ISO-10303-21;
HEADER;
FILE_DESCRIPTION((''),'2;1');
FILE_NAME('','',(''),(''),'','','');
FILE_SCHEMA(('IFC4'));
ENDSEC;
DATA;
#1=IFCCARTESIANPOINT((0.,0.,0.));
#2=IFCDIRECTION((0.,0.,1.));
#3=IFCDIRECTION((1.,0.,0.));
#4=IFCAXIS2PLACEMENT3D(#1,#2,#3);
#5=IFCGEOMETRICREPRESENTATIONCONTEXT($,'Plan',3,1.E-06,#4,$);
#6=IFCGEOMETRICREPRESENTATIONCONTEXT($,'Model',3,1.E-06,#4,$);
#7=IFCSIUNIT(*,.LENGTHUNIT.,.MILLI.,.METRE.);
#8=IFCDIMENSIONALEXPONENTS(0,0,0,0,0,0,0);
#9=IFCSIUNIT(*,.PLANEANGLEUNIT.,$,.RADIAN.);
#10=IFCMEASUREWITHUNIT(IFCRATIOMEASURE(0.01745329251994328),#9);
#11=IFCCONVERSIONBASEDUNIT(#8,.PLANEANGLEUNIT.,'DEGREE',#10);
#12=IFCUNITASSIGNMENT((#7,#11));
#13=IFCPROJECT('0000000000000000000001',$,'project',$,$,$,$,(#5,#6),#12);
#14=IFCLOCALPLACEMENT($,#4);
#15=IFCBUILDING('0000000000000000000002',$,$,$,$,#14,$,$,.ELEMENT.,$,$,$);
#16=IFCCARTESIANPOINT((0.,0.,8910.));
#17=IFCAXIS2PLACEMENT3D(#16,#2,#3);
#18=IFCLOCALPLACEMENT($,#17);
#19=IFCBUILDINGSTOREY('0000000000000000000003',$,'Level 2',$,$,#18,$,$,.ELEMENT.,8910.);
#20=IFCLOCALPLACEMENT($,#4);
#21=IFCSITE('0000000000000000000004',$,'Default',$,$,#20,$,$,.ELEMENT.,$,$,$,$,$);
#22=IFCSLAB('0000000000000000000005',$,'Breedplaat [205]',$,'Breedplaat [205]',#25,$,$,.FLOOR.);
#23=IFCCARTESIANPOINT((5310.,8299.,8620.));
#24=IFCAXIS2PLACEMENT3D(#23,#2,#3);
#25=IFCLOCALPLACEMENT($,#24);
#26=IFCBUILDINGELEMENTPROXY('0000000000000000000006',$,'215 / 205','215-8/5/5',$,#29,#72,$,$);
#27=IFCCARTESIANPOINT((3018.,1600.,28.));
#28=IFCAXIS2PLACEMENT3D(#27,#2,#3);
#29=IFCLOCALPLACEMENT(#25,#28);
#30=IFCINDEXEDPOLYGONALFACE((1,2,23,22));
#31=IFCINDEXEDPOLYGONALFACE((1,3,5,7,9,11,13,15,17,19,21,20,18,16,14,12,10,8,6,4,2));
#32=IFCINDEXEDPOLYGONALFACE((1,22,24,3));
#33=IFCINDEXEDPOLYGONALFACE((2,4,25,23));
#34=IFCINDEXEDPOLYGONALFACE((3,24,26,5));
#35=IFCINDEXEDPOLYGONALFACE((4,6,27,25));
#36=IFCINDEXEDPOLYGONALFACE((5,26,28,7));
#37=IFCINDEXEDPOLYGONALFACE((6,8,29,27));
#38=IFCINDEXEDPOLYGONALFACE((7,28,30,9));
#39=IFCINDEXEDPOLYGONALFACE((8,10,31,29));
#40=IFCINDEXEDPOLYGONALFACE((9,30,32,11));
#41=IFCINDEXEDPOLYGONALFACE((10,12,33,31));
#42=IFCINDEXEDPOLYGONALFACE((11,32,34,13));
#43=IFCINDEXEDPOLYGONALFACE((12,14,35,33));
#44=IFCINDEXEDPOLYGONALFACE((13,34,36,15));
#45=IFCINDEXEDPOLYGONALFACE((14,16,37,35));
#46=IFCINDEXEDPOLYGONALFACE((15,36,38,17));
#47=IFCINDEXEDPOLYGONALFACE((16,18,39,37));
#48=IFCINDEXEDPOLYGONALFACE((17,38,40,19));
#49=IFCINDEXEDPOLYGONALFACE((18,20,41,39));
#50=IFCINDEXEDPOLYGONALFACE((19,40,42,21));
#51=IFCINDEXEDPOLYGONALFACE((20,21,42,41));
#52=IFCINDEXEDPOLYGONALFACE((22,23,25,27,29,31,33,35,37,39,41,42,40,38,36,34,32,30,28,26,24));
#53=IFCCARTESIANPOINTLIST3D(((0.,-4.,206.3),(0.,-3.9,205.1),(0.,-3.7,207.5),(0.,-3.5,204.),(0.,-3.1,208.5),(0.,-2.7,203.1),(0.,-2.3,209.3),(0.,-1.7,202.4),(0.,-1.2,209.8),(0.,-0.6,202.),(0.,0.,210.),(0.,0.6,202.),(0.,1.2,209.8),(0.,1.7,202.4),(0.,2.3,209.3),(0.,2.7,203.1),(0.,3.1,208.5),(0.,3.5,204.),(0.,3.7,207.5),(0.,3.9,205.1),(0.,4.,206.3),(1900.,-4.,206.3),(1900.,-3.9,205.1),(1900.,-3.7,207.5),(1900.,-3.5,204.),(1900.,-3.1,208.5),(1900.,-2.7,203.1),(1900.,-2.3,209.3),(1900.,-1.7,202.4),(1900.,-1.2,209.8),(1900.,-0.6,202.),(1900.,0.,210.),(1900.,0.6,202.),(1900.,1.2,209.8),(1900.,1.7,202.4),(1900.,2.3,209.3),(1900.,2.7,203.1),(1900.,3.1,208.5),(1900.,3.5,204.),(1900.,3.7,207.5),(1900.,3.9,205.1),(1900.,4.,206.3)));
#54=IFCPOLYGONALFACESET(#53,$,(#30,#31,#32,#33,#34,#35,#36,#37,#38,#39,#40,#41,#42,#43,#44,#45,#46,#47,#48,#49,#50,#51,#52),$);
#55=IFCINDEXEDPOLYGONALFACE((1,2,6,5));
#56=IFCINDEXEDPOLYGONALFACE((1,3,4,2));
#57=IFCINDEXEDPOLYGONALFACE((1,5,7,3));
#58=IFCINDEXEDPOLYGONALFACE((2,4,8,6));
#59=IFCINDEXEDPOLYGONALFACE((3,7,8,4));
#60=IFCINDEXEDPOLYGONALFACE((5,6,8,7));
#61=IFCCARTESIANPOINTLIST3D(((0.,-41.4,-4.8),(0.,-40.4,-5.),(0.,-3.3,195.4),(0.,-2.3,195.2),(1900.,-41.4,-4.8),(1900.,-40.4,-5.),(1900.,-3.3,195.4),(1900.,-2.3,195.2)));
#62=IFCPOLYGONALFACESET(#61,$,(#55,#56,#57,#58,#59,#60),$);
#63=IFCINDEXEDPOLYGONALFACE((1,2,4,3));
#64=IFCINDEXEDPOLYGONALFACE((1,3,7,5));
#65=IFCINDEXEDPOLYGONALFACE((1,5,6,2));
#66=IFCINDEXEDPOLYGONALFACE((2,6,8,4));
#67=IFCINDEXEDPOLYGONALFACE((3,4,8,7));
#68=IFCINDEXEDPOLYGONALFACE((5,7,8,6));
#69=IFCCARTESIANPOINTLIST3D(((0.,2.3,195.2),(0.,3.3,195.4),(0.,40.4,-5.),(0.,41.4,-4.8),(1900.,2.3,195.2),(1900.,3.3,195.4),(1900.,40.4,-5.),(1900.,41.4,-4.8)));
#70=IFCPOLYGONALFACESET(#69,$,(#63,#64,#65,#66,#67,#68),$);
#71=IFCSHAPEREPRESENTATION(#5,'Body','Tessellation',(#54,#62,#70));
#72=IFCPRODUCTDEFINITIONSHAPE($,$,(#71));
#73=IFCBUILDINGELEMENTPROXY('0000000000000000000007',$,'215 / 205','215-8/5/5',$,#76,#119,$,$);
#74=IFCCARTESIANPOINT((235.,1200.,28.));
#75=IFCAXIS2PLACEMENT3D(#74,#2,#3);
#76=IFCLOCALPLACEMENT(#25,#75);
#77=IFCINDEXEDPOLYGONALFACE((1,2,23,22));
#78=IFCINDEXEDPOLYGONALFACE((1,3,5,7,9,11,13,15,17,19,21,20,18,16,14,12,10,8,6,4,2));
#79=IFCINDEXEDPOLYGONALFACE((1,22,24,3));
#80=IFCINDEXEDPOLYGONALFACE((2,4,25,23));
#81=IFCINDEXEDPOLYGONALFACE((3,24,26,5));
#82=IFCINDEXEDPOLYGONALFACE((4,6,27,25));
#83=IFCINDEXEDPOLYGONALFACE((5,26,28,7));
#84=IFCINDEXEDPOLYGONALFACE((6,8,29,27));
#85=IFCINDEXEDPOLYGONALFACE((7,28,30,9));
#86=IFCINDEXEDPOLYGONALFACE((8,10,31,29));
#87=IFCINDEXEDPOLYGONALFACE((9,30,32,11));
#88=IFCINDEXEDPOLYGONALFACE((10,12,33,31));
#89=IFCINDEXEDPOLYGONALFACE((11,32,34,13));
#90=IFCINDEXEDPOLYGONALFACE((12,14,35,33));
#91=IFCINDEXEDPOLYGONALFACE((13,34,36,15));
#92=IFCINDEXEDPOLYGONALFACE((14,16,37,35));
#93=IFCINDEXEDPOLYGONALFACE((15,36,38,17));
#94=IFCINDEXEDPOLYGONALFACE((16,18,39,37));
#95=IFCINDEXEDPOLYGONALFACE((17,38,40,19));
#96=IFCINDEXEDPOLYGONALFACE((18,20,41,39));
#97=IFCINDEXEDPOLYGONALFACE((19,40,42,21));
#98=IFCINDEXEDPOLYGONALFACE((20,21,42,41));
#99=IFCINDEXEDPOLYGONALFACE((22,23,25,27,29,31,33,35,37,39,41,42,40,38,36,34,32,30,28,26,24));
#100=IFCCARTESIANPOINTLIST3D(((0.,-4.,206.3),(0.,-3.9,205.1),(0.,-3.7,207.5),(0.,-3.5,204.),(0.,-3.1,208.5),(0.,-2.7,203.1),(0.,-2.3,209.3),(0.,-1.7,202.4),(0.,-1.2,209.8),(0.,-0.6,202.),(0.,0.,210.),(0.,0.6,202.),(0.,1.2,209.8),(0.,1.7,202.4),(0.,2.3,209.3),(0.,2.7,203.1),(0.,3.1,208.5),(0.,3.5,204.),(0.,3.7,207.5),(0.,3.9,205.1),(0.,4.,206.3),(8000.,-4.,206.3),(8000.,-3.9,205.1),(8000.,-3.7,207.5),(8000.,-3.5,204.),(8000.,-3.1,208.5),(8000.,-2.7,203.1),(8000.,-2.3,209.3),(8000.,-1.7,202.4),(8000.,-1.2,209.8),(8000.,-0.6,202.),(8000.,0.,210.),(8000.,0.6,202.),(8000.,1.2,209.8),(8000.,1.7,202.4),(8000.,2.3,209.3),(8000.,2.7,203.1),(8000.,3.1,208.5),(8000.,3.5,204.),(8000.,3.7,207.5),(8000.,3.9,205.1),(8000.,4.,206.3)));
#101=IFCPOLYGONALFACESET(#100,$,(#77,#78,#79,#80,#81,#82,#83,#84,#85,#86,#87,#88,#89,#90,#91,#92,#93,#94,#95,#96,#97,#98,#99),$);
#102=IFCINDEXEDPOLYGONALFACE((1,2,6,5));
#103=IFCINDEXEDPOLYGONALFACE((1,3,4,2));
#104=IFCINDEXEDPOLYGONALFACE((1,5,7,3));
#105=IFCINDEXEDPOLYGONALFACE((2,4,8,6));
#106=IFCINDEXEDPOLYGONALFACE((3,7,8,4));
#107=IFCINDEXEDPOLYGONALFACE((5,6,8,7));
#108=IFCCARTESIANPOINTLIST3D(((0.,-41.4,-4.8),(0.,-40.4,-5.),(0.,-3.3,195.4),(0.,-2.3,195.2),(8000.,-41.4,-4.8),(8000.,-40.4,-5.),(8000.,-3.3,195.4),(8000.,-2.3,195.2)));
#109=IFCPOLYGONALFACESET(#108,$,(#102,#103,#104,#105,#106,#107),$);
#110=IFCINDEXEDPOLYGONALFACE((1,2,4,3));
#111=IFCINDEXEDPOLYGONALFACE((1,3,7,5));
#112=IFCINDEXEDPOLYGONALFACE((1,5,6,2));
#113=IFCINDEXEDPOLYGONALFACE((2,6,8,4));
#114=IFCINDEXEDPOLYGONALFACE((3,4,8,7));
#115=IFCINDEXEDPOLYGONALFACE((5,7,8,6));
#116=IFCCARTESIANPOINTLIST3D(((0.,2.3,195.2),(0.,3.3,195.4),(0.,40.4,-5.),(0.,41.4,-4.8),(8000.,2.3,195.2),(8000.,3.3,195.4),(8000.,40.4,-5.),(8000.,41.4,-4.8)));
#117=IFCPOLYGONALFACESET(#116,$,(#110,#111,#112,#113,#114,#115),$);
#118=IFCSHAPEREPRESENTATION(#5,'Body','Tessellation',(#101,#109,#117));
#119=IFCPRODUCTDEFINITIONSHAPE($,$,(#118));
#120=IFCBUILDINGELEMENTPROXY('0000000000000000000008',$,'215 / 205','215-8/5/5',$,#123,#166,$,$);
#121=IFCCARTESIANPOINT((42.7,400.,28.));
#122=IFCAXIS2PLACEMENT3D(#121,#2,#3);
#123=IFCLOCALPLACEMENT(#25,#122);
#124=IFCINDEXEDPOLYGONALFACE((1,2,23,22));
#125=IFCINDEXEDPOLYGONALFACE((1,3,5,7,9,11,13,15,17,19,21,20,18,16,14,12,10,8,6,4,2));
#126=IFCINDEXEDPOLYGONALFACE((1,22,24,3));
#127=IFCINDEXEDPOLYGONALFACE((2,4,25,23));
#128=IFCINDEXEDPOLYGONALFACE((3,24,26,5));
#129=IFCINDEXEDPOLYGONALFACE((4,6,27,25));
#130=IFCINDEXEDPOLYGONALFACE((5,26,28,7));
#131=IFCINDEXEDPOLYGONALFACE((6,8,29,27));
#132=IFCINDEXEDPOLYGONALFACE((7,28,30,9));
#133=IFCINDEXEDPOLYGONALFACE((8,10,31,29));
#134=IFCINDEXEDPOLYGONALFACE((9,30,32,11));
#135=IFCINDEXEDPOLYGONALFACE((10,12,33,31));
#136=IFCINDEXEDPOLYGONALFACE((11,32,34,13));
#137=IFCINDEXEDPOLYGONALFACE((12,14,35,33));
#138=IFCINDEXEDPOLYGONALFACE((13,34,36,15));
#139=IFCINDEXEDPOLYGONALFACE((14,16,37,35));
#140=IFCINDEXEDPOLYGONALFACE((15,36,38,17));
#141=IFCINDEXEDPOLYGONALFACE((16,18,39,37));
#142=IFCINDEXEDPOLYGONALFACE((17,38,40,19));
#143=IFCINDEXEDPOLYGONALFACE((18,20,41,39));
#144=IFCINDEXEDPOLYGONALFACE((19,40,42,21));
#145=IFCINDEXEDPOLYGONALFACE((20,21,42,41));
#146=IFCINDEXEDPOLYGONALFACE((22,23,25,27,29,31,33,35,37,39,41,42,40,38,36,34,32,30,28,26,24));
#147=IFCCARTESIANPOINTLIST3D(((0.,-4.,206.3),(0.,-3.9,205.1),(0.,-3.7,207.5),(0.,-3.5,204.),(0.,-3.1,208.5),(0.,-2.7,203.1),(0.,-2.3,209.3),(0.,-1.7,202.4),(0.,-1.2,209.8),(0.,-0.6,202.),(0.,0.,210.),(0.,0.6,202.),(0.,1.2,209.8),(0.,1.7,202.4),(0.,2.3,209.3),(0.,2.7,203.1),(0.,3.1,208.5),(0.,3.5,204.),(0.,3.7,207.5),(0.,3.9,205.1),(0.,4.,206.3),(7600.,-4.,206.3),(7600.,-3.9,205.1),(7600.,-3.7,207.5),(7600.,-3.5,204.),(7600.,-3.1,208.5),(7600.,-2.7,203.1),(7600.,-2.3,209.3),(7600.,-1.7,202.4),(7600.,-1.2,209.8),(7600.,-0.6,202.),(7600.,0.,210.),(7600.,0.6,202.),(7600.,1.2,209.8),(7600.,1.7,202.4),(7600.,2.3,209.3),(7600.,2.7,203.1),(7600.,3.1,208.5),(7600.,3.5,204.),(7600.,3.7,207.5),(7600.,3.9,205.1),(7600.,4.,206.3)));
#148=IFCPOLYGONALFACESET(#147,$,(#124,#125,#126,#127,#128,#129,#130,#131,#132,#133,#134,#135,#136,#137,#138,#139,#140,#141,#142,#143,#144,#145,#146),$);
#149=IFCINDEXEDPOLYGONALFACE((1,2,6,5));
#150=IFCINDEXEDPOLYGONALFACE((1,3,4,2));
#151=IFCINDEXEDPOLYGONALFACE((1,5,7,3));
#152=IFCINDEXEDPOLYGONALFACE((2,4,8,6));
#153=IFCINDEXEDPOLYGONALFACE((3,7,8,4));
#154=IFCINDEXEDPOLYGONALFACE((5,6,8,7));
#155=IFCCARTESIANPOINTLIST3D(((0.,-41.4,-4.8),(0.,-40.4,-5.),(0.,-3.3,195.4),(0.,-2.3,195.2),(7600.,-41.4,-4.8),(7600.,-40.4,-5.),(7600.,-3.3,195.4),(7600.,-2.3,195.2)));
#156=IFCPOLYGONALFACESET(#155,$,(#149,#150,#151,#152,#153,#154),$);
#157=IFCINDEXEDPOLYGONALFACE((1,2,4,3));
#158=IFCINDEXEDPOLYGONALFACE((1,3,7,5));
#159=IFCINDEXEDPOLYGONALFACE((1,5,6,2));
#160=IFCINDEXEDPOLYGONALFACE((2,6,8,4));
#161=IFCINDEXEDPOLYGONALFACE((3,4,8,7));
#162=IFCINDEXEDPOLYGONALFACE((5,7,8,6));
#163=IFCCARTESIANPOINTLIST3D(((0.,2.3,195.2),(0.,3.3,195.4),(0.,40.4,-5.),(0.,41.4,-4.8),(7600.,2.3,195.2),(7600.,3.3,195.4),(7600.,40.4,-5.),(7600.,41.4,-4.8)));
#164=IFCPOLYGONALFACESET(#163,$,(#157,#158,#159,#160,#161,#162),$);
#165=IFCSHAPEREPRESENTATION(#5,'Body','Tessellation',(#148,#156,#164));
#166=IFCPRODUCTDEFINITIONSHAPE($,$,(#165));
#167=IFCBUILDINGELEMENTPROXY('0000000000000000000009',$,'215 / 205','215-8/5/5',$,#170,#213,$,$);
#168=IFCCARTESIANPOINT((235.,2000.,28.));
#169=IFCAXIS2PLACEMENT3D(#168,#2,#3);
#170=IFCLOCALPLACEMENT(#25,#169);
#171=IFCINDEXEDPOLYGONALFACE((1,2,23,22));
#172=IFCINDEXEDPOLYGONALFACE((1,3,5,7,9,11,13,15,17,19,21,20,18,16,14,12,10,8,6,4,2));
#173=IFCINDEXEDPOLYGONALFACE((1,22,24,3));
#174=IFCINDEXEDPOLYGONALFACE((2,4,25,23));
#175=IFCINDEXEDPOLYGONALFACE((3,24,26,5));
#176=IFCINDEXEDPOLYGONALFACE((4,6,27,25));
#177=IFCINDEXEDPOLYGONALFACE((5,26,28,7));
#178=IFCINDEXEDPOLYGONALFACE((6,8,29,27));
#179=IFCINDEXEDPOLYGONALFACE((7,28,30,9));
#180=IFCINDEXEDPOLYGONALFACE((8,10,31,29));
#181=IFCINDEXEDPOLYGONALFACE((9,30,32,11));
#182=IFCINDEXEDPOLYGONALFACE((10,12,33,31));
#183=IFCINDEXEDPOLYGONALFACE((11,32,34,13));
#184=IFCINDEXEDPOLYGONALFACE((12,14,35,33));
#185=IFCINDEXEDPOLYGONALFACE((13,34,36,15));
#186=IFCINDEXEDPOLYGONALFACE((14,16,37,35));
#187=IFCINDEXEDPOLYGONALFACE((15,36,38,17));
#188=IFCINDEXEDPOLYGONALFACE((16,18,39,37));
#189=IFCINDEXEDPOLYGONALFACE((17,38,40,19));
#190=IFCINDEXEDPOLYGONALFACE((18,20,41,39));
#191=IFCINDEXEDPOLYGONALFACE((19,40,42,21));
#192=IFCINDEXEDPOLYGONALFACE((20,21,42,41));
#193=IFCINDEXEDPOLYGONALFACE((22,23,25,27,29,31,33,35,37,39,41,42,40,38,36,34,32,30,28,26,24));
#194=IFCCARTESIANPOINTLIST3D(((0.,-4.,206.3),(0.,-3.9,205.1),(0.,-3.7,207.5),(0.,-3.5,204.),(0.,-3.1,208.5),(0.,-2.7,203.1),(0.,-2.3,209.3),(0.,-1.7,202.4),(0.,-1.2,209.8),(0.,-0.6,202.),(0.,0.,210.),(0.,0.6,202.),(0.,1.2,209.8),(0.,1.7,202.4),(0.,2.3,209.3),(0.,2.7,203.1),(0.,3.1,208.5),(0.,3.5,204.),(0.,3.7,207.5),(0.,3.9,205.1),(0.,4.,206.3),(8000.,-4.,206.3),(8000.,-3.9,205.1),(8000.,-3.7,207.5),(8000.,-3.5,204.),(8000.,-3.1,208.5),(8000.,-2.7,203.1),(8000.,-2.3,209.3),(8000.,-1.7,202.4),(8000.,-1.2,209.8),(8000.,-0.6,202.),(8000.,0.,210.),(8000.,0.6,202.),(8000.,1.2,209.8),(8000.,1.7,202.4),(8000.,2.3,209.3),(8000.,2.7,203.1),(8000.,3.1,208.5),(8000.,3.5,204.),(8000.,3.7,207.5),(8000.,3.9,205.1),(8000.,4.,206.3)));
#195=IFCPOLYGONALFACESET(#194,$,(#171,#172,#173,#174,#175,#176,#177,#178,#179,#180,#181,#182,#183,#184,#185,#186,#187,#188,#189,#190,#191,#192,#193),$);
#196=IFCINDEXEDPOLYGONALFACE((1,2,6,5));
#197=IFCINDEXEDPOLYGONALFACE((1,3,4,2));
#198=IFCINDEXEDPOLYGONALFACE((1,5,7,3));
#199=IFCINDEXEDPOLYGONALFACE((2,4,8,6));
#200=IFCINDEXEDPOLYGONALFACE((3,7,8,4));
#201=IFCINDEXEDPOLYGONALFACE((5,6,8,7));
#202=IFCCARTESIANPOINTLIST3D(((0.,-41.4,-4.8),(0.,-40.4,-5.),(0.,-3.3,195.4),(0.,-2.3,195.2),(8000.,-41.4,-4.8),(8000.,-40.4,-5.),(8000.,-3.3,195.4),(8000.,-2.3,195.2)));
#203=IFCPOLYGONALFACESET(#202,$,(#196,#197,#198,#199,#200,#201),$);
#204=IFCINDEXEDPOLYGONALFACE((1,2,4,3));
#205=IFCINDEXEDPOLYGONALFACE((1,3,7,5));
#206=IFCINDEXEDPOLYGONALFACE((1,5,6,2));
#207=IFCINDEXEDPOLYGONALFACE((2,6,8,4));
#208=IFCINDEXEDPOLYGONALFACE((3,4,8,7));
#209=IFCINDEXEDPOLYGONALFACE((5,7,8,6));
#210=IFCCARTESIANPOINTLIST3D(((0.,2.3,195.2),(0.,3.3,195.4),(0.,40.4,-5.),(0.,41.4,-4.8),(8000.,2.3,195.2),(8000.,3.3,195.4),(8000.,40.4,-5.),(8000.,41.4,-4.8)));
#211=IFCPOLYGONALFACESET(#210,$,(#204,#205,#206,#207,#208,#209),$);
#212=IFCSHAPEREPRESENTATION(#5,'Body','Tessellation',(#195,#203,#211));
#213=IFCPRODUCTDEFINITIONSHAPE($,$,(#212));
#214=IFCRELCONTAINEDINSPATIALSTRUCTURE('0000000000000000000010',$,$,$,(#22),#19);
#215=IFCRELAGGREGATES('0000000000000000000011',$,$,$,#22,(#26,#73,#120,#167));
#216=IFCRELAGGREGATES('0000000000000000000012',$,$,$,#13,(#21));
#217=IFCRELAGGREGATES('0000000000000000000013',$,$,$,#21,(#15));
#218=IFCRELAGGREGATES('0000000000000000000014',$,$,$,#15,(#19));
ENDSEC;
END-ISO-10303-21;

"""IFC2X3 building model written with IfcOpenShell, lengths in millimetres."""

from ifc_helpers import new_model, entity, si_unit, converted_unit, frame, origin_with_axes, origin_2d_with_axis, place, context, project, spatial, rectangle, circle, extrude, element, aggregate, save


model = new_model("IFC2X3")

# Units and contexts
plan_context = context("Plan", 3, precision=1e-06, world=origin_with_axes())
model_context = context("Model", 3, precision=1e-06, world=origin_with_axes())
ifc_project = project(units=[si_unit("LENGTHUNIT", "METRE", prefix="MILLI"), converted_unit("PLANEANGLEUNIT", "DEGREE", entity("IfcRatioMeasure", 0.01745329251994328), si_unit("PLANEANGLEUNIT", "RADIAN"), dimensions=[0, 0, 0, 0, 0, 0, 0])], contexts=[plan_context, model_context])

# Site, building, storey
site_placement = place(None, origin_with_axes())
site = spatial("IfcSite", under=ifc_project, at=site_placement, Name="Default", CompositionType="ELEMENT")
building_placement = place(None, origin_with_axes())
building = spatial("IfcBuilding", under=site, at=building_placement, CompositionType="ELEMENT")
storey_placement = place(None, frame((0.0, 0.0, 8910.0), z_axis=(0.0, 0.0, 1.0), x_axis=(1.0, 0.0, 0.0)))
storey = spatial("IfcBuildingStorey", under=building, at=storey_placement, Name="Level 2", CompositionType="ELEMENT", Elevation=8910.0)

# Slab, building element proxies
slab_1_placement = place(None, frame((5310.0, 8299.0, 8620.0), z_axis=(0.0, 0.0, 1.0), x_axis=(1.0, 0.0, 0.0)))
slab_1 = element("IfcSlab", 1, at=slab_1_placement, inside=storey, Name="Breedplaat [205]", ObjectType="Breedplaat [205]", PredefinedType="FLOOR")
proxy_1_placement = place(slab_1_placement, frame((3018.0, 1600.0, 28.0), z_axis=(0.0, 0.0, 1.0), x_axis=(1.0, 0.0, 0.0)))
proxy_1 = element("IfcBuildingElementProxy", 2, at=proxy_1_placement, Name="215 / 205", Description="215-8/5/5", context=plan_context, shape_type="SweptSolid", body=[
    extrude(circle(Radius=4.0, at=origin_2d_with_axis()), frame((0.0, 0.0, 206.0), z_axis=(1.0, 0.0, 0.0), x_axis=(0.0, 0.0, 1.0)), (0.0, 0.0, 1.0), 1900.0),
    extrude(rectangle(XDim=203.8, YDim=1.0, at=origin_2d_with_axis()), frame((0.0, -21.9, 95.2), z_axis=(1.0, 0.0, 0.0), x_axis=(0.0, 0.187112, 0.982339)), (0.0, 0.0, 1.0), 1900.0),
    extrude(rectangle(XDim=203.8, YDim=1.0, at=origin_2d_with_axis()), frame((0.0, 21.9, 95.2), z_axis=(1.0, 0.0, 0.0), x_axis=(0.0, -0.187112, 0.982339)), (0.0, 0.0, 1.0), 1900.0),
])
proxy_2_placement = place(slab_1_placement, frame((235.0, 1200.0, 28.0), z_axis=(0.0, 0.0, 1.0), x_axis=(1.0, 0.0, 0.0)))
proxy_2 = element("IfcBuildingElementProxy", 3, at=proxy_2_placement, Name="215 / 205", Description="215-8/5/5", context=plan_context, shape_type="SweptSolid", body=[
    extrude(circle(Radius=4.0, at=origin_2d_with_axis()), frame((0.0, 0.0, 206.0), z_axis=(1.0, 0.0, 0.0), x_axis=(0.0, 0.0, 1.0)), (0.0, 0.0, 1.0), 8000.0),
    extrude(rectangle(XDim=203.8, YDim=1.0, at=origin_2d_with_axis()), frame((0.0, -21.9, 95.2), z_axis=(1.0, 0.0, 0.0), x_axis=(0.0, 0.187112, 0.982339)), (0.0, 0.0, 1.0), 8000.0),
    extrude(rectangle(XDim=203.8, YDim=1.0, at=origin_2d_with_axis()), frame((0.0, 21.9, 95.2), z_axis=(1.0, 0.0, 0.0), x_axis=(0.0, -0.187112, 0.982339)), (0.0, 0.0, 1.0), 8000.0),
])
proxy_3_placement = place(slab_1_placement, frame((42.7, 400.0, 28.0), z_axis=(0.0, 0.0, 1.0), x_axis=(1.0, 0.0, 0.0)))
proxy_3 = element("IfcBuildingElementProxy", 4, at=proxy_3_placement, Name="215 / 205", Description="215-8/5/5", context=plan_context, shape_type="SweptSolid", body=[
    extrude(circle(Radius=4.0, at=origin_2d_with_axis()), frame((0.0, 0.0, 206.0), z_axis=(1.0, 0.0, 0.0), x_axis=(0.0, 0.0, 1.0)), (0.0, 0.0, 1.0), 7600.0),
    extrude(rectangle(XDim=203.8, YDim=1.0, at=origin_2d_with_axis()), frame((0.0, -21.9, 95.2), z_axis=(1.0, 0.0, 0.0), x_axis=(0.0, 0.187112, 0.982339)), (0.0, 0.0, 1.0), 7600.0),
    extrude(rectangle(XDim=203.8, YDim=1.0, at=origin_2d_with_axis()), frame((0.0, 21.9, 95.2), z_axis=(1.0, 0.0, 0.0), x_axis=(0.0, -0.187112, 0.982339)), (0.0, 0.0, 1.0), 7600.0),
])
proxy_4_placement = place(slab_1_placement, frame((235.0, 2000.0, 28.0), z_axis=(0.0, 0.0, 1.0), x_axis=(1.0, 0.0, 0.0)))
proxy_4 = element("IfcBuildingElementProxy", 5, at=proxy_4_placement, Name="215 / 205", Description="215-8/5/5", context=plan_context, shape_type="SweptSolid", body=[
    extrude(circle(Radius=4.0, at=origin_2d_with_axis()), frame((0.0, 0.0, 206.0), z_axis=(1.0, 0.0, 0.0), x_axis=(0.0, 0.0, 1.0)), (0.0, 0.0, 1.0), 8000.0),
    extrude(rectangle(XDim=203.8, YDim=1.0, at=origin_2d_with_axis()), frame((0.0, -21.9, 95.2), z_axis=(1.0, 0.0, 0.0), x_axis=(0.0, 0.187112, 0.982339)), (0.0, 0.0, 1.0), 8000.0),
    extrude(rectangle(XDim=203.8, YDim=1.0, at=origin_2d_with_axis()), frame((0.0, 21.9, 95.2), z_axis=(1.0, 0.0, 0.0), x_axis=(0.0, -0.187112, 0.982339)), (0.0, 0.0, 1.0), 8000.0),
])
aggregate(slab_1, [proxy_1, proxy_2, proxy_3, proxy_4])

save(model, "model.ifc")
